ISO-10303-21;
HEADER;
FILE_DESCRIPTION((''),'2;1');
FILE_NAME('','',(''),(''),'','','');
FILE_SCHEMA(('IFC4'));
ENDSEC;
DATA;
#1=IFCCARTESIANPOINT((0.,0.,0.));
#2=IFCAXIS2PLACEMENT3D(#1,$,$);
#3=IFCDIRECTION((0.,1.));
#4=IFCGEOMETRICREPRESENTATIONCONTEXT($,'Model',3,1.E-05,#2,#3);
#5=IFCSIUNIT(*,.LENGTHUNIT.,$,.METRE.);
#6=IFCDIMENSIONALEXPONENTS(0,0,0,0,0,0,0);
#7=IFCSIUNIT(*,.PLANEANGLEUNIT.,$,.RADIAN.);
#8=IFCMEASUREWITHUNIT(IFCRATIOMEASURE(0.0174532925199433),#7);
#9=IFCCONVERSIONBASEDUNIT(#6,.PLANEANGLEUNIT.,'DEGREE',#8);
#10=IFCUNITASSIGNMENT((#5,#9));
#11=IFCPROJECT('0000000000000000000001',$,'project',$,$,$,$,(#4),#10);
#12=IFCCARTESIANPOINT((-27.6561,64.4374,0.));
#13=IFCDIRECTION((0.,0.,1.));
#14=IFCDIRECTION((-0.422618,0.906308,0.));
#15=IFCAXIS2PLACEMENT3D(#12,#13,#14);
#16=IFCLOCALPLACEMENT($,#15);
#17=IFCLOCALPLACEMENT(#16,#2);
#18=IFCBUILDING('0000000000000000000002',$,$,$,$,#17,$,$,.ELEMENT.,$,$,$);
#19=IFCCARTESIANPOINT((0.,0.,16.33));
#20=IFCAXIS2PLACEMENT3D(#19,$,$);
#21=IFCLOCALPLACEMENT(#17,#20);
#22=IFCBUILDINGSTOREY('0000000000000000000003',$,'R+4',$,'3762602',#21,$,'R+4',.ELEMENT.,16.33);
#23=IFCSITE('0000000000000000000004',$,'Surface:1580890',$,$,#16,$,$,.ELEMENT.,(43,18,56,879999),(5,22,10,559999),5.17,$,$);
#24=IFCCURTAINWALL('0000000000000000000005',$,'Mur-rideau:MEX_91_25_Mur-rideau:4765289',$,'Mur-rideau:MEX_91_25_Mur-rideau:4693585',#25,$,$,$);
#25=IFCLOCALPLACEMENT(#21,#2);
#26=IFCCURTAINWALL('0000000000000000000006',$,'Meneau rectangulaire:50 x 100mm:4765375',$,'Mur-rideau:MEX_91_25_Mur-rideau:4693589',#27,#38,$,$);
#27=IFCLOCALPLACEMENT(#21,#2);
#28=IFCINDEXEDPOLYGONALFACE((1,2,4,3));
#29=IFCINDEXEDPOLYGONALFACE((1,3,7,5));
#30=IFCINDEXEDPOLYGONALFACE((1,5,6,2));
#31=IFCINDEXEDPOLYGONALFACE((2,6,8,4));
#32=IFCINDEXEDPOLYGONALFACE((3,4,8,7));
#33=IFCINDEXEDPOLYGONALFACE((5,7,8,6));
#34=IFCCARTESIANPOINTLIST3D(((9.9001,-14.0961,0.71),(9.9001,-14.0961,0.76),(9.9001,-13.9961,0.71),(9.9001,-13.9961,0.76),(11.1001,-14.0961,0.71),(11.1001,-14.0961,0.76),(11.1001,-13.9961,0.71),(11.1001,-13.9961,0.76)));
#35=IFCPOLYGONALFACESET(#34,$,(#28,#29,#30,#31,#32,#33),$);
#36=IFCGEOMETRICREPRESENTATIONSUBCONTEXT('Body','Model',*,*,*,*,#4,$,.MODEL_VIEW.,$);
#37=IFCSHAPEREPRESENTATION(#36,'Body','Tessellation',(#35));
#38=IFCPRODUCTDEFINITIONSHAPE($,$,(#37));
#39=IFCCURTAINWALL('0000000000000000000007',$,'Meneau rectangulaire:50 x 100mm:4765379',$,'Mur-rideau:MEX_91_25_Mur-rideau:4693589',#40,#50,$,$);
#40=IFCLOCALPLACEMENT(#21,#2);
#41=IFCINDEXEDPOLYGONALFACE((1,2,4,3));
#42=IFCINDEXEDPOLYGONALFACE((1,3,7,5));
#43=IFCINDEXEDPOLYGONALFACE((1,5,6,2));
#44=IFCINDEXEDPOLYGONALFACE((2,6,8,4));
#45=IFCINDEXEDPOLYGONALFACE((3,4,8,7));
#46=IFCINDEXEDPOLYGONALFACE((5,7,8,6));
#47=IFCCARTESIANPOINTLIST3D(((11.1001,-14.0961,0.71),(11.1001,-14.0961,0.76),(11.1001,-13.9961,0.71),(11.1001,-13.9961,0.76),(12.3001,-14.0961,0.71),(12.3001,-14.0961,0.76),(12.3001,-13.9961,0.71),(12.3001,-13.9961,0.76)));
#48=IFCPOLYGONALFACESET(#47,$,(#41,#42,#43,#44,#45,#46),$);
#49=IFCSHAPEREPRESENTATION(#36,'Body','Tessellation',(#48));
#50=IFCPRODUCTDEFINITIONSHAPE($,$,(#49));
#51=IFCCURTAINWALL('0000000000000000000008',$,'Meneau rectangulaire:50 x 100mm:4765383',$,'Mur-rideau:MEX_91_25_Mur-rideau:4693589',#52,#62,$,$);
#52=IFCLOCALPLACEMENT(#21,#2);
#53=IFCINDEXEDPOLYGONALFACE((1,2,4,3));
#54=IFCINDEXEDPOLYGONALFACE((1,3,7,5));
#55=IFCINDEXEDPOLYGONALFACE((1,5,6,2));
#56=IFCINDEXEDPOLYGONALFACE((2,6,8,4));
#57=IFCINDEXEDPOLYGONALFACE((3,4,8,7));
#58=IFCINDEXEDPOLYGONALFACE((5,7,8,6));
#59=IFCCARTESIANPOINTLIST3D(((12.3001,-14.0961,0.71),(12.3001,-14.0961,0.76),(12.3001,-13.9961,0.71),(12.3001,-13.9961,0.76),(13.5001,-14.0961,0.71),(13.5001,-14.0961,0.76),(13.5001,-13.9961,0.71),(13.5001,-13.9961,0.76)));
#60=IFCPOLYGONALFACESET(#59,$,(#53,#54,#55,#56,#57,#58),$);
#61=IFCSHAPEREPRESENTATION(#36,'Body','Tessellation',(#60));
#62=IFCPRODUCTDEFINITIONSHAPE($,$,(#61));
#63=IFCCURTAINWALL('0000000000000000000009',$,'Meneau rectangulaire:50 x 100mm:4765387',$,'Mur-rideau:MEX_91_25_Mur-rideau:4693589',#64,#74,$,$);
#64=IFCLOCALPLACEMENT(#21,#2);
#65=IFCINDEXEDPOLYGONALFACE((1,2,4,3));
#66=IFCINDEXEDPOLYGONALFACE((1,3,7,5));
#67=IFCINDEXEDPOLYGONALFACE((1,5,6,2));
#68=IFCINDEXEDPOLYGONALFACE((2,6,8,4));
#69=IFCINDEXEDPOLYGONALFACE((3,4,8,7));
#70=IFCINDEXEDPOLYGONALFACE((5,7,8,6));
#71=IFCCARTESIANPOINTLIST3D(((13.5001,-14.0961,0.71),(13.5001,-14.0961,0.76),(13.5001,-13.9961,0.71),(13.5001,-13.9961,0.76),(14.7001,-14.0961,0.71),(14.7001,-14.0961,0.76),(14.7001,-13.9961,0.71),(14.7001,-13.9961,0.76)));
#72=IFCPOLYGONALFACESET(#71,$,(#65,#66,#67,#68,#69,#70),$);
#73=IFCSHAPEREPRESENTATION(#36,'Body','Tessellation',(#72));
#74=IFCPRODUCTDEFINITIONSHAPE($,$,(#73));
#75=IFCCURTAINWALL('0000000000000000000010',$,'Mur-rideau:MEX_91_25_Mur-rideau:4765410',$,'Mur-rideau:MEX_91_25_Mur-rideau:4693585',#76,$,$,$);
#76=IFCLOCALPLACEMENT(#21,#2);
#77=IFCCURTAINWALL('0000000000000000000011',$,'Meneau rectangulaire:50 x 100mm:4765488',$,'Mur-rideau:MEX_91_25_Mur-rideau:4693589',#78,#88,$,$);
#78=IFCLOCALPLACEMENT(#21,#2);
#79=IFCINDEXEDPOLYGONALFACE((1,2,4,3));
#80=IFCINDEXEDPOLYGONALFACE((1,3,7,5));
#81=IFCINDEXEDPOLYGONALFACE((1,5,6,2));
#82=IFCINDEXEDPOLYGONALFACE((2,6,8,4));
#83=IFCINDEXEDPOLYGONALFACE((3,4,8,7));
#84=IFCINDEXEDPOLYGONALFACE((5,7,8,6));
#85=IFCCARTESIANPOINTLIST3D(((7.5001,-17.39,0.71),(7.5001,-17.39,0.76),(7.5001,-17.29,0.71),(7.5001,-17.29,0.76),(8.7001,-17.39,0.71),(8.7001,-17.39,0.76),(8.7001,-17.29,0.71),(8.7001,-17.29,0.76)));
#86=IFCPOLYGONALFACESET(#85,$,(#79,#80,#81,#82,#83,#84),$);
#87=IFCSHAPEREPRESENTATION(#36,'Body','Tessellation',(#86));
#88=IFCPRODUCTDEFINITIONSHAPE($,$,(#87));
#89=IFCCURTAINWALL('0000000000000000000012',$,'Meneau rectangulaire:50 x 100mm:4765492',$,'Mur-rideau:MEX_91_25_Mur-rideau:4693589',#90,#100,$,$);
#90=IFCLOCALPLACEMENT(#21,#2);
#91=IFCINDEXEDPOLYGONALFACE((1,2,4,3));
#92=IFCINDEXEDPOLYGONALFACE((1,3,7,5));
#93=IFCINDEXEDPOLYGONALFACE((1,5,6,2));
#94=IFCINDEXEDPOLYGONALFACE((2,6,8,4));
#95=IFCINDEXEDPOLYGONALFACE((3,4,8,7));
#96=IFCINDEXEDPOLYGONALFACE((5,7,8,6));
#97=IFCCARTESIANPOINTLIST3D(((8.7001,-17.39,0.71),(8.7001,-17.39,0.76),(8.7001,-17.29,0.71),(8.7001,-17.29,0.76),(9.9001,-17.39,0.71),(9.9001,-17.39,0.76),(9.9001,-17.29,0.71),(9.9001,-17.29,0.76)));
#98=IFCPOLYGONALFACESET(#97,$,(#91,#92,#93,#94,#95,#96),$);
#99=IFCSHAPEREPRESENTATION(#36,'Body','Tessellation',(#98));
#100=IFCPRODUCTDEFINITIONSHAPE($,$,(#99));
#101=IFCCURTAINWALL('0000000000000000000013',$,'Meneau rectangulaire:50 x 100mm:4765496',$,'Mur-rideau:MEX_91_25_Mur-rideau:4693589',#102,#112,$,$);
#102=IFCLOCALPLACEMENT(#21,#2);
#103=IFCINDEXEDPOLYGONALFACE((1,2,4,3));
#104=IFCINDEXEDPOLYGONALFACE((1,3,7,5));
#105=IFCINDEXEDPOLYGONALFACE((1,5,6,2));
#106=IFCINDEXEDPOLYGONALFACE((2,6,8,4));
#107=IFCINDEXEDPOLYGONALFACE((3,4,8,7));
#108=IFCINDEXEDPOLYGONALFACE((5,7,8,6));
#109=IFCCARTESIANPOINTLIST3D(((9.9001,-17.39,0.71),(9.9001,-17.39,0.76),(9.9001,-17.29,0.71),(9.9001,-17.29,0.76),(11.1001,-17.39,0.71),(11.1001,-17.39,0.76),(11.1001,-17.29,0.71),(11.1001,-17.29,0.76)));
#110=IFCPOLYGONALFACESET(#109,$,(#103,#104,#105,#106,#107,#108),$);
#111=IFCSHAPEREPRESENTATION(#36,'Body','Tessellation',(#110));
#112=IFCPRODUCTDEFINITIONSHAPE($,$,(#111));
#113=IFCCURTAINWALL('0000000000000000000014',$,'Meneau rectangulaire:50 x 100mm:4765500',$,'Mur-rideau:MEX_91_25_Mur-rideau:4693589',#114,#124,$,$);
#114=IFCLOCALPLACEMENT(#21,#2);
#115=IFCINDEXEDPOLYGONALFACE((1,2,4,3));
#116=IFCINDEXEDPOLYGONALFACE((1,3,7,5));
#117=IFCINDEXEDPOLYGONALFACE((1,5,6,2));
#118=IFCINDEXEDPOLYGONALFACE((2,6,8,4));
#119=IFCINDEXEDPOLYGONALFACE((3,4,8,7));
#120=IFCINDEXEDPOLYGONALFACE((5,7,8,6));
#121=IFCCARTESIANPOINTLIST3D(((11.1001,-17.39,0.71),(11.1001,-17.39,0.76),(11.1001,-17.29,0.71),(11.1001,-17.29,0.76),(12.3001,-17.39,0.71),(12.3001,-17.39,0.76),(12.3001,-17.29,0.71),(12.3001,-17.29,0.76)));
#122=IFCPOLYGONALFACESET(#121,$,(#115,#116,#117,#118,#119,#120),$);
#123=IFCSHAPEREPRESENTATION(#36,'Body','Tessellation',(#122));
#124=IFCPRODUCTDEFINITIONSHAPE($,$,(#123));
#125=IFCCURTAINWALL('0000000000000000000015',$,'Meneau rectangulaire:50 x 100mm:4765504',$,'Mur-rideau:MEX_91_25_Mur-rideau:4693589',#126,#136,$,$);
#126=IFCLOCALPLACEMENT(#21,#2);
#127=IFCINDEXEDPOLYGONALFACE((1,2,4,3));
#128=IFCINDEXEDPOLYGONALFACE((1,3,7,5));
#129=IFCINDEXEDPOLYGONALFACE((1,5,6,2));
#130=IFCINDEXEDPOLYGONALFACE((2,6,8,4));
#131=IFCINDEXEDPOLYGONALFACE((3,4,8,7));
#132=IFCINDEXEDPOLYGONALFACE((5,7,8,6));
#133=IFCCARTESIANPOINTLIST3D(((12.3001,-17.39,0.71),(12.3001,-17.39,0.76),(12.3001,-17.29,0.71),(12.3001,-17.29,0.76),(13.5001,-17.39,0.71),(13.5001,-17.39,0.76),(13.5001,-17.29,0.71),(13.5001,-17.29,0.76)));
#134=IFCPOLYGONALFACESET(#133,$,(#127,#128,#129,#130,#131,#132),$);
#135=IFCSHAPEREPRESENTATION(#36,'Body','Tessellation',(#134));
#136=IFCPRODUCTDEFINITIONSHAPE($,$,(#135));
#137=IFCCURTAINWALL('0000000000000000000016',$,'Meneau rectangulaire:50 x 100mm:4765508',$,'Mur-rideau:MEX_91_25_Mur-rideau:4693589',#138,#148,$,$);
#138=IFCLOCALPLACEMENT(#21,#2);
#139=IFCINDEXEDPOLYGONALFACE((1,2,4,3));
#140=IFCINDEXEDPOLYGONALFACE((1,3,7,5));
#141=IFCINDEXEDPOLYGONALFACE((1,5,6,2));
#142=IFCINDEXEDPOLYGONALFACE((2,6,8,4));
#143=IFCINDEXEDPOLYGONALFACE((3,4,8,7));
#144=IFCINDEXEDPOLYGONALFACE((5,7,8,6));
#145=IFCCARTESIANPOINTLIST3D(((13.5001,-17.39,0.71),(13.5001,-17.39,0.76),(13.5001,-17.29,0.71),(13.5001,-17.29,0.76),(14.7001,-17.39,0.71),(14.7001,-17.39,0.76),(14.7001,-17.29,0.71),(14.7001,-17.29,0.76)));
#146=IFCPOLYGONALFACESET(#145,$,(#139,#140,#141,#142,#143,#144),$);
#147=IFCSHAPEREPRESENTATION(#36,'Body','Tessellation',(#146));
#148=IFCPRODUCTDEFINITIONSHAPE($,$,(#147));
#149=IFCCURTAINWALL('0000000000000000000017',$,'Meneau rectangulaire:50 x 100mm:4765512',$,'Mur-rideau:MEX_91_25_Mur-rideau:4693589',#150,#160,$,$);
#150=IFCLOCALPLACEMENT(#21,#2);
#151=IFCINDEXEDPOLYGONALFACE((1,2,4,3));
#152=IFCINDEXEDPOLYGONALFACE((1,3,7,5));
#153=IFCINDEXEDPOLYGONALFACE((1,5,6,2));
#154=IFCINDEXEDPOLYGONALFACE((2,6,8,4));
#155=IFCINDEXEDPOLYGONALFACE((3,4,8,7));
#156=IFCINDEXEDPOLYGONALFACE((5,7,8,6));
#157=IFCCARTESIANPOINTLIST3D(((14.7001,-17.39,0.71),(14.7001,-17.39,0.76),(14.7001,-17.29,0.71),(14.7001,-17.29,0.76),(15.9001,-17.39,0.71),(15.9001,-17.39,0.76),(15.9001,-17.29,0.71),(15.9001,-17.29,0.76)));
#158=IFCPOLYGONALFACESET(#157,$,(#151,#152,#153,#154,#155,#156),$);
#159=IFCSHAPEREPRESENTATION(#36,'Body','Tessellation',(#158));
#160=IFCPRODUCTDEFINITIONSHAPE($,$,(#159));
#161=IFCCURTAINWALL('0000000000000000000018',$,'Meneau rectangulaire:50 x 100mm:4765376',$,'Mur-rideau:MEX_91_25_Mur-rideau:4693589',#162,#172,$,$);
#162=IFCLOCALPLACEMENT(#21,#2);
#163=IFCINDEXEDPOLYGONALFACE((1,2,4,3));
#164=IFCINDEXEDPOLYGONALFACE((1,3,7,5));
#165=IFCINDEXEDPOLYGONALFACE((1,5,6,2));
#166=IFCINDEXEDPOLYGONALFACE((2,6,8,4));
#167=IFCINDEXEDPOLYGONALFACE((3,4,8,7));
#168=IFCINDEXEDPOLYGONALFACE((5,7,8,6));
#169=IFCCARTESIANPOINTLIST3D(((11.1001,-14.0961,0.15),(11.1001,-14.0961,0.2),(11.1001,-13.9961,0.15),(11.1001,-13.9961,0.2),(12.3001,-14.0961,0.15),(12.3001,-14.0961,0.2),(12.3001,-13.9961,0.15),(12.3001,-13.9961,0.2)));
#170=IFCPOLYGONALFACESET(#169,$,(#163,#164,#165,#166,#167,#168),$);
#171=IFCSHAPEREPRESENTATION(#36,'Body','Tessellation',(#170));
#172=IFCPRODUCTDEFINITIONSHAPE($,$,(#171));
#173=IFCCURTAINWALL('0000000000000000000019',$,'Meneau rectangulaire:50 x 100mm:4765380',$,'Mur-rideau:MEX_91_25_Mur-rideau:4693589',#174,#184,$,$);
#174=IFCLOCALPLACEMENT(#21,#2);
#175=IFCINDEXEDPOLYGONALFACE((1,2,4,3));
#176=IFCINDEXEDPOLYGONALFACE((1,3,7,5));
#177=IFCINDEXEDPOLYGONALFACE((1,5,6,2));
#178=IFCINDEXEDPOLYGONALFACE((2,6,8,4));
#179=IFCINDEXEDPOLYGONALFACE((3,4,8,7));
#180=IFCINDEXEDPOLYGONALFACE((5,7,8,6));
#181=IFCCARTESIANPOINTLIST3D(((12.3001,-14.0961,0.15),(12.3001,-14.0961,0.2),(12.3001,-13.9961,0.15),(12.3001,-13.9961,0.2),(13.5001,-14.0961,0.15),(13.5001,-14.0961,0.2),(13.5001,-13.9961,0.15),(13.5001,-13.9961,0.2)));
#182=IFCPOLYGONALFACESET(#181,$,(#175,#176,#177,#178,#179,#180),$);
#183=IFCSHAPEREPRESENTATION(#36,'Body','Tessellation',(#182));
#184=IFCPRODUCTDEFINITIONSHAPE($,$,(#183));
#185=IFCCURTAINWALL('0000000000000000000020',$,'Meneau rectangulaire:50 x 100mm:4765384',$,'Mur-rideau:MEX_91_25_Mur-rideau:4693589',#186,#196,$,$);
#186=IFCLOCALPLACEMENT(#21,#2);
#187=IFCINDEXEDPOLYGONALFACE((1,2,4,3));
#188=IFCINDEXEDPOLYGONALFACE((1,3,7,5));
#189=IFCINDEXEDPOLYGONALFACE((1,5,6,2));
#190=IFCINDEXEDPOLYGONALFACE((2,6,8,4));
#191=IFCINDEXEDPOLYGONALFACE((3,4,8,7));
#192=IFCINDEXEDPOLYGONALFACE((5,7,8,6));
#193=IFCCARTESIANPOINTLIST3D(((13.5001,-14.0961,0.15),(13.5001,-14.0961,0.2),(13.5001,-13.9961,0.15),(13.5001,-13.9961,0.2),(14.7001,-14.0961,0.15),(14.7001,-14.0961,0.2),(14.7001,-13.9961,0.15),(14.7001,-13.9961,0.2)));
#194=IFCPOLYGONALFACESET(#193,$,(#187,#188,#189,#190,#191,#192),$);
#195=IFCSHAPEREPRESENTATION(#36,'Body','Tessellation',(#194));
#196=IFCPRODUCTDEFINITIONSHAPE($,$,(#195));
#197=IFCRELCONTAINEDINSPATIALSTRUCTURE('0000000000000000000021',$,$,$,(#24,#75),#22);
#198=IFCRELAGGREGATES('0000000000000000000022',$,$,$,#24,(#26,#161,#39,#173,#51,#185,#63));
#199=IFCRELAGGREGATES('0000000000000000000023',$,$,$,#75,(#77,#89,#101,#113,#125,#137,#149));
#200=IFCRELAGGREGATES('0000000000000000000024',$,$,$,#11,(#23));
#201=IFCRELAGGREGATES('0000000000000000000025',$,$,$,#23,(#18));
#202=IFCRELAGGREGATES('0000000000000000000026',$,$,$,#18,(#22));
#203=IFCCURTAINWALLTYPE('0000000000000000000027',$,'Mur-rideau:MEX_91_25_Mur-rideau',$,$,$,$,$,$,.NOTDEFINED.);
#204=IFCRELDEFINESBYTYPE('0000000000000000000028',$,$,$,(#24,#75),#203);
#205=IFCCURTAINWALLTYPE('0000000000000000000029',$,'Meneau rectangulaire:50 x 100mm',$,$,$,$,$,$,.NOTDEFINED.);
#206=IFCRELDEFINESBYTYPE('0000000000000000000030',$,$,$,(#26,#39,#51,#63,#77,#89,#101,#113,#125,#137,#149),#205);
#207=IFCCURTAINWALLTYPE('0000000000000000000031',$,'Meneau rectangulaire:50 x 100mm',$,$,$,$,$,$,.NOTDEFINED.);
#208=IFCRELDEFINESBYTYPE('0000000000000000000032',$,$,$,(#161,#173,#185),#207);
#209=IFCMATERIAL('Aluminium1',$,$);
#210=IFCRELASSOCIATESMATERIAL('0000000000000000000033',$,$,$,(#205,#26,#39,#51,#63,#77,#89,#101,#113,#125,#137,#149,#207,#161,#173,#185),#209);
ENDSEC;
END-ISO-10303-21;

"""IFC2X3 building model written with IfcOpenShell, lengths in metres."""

from ifc_helpers import new_model, entity, si_unit, converted_unit, direction, frame, origin, origin_2d_with_axis, place, context, subcontext, project, spatial, rectangle, extrude, source, transform, mapped, material, type_object, type_shapes, element, aggregate, save


model = new_model("IFC2X3")

# Units and contexts
model_context = context("Model", 3, precision=1e-05, world=origin(), true_north=direction((0.0, 1.0)))
body_context = subcontext(model_context, "Body", "Model", "MODEL_VIEW")
ifc_project = project(units=[si_unit("LENGTHUNIT", "METRE"), converted_unit("PLANEANGLEUNIT", "DEGREE", entity("IfcRatioMeasure", 0.0174532925199433), si_unit("PLANEANGLEUNIT", "RADIAN"), dimensions=[0, 0, 0, 0, 0, 0, 0])], contexts=[model_context])

# Site, building, storey
site_placement = place(None, frame((-27.6561, 64.4374, 0.0), z_axis=(0.0, 0.0, 1.0), x_axis=(-0.422618, 0.906308, 0.0)))
site = spatial("IfcSite", under=ifc_project, at=site_placement, Name="Surface:1580890", CompositionType="ELEMENT", RefLatitude=(43, 18, 56, 879999), RefLongitude=(5, 22, 10, 559999), RefElevation=5.17)
building_placement = place(site_placement, origin())
building = spatial("IfcBuilding", under=site, at=building_placement, CompositionType="ELEMENT")
storey_placement = place(building_placement, frame((0.0, 0.0, 16.33)))
storey = spatial("IfcBuildingStorey", under=building, at=storey_placement, Name="R+4", ObjectType="3762602", LongName="R+4", CompositionType="ELEMENT", Elevation=16.33)

# Curtain walls
curtain_wall_type_1 = type_object("IfcCurtainWallType", Name="Mur-rideau:MEX_91_25_Mur-rideau", PredefinedType="NOTDEFINED")
curtain_wall_1_placement = place(storey_placement, frame((0.0, 0.0, -16.33)))
curtain_wall_1 = element("IfcCurtainWall", 1, at=curtain_wall_1_placement, inside=storey, type_object=curtain_wall_type_1, Name="Mur-rideau:MEX_91_25_Mur-rideau:4765289", ObjectType="Mur-rideau:MEX_91_25_Mur-rideau:4693585")
ifc_material = material(Name="Aluminium1")
curtain_wall_type_2 = type_object("IfcCurtainWallType", Name="Meneau rectangulaire:50 x 100mm", PredefinedType="NOTDEFINED", material=ifc_material)
shared_shape_1 = source(origin(), body_context, "Body", "SweptSolid", [
    extrude(rectangle(XDim=0.05, YDim=0.1, at=origin_2d_with_axis()), frame((-0.025, 0.0, -1.2), z_axis=(0.0, 0.0, 1.0), x_axis=(-1.0, 0.0, 0.0)), (0.0, 0.0, 1.0), 1.2),
])
type_shapes(curtain_wall_type_2, [shared_shape_1])
placement = place(building_placement, frame((0.0, 0.0, -2.88)))
curtain_wall_2_placement = place(placement, frame((11.1001, -14.0461, 19.97), z_axis=(1.0, 0.0, 0.0), x_axis=(0.0, 0.0, 1.0)))
curtain_wall_2 = element("IfcCurtainWall", 2, at=curtain_wall_2_placement, type_object=curtain_wall_type_2, material=ifc_material, Name="Meneau rectangulaire:50 x 100mm:4765375", ObjectType="Mur-rideau:MEX_91_25_Mur-rideau:4693589", context=body_context, shape_type="MappedRepresentation", body=[
    mapped(shared_shape_1, transform((0.0, 0.0, 0.0), scale=1.0)),
])
curtain_wall_3_placement = place(placement, frame((12.3001, -14.0461, 19.97), z_axis=(1.0, 0.0, 0.0), x_axis=(0.0, 0.0, 1.0)))
curtain_wall_3 = element("IfcCurtainWall", 3, at=curtain_wall_3_placement, type_object=curtain_wall_type_2, material=ifc_material, Name="Meneau rectangulaire:50 x 100mm:4765379", ObjectType="Mur-rideau:MEX_91_25_Mur-rideau:4693589", context=body_context, shape_type="MappedRepresentation", body=[
    mapped(shared_shape_1, transform((0.0, 0.0, 0.0), scale=1.0)),
])
curtain_wall_4_placement = place(placement, frame((13.5001, -14.0461, 19.97), z_axis=(1.0, 0.0, 0.0), x_axis=(0.0, 0.0, 1.0)))
curtain_wall_4 = element("IfcCurtainWall", 4, at=curtain_wall_4_placement, type_object=curtain_wall_type_2, material=ifc_material, Name="Meneau rectangulaire:50 x 100mm:4765383", ObjectType="Mur-rideau:MEX_91_25_Mur-rideau:4693589", context=body_context, shape_type="MappedRepresentation", body=[
    mapped(shared_shape_1, transform((0.0, 0.0, 0.0), scale=1.0)),
])
curtain_wall_5_placement = place(placement, frame((14.7001, -14.0461, 19.97), z_axis=(1.0, 0.0, 0.0), x_axis=(0.0, 0.0, 1.0)))
curtain_wall_5 = element("IfcCurtainWall", 5, at=curtain_wall_5_placement, type_object=curtain_wall_type_2, material=ifc_material, Name="Meneau rectangulaire:50 x 100mm:4765387", ObjectType="Mur-rideau:MEX_91_25_Mur-rideau:4693589", context=body_context, shape_type="MappedRepresentation", body=[
    mapped(shared_shape_1, transform((0.0, 0.0, 0.0), scale=1.0)),
])
curtain_wall_6_placement = place(storey_placement, frame((0.0, 0.0, -16.33)))
curtain_wall_6 = element("IfcCurtainWall", 6, at=curtain_wall_6_placement, inside=storey, type_object=curtain_wall_type_1, Name="Mur-rideau:MEX_91_25_Mur-rideau:4765410", ObjectType="Mur-rideau:MEX_91_25_Mur-rideau:4693585")
curtain_wall_7_placement = place(placement, frame((8.7001, -17.34, 19.97), z_axis=(1.0, 0.0, 0.0), x_axis=(0.0, 0.0, 1.0)))
curtain_wall_7 = element("IfcCurtainWall", 7, at=curtain_wall_7_placement, type_object=curtain_wall_type_2, material=ifc_material, Name="Meneau rectangulaire:50 x 100mm:4765488", ObjectType="Mur-rideau:MEX_91_25_Mur-rideau:4693589", context=body_context, shape_type="MappedRepresentation", body=[
    mapped(shared_shape_1, transform((0.0, 0.0, 0.0), scale=1.0)),
])
curtain_wall_8_placement = place(placement, frame((9.9001, -17.34, 19.97), z_axis=(1.0, 0.0, 0.0), x_axis=(0.0, 0.0, 1.0)))
curtain_wall_8 = element("IfcCurtainWall", 8, at=curtain_wall_8_placement, type_object=curtain_wall_type_2, material=ifc_material, Name="Meneau rectangulaire:50 x 100mm:4765492", ObjectType="Mur-rideau:MEX_91_25_Mur-rideau:4693589", context=body_context, shape_type="MappedRepresentation", body=[
    mapped(shared_shape_1, transform((0.0, 0.0, 0.0), scale=1.0)),
])
curtain_wall_9_placement = place(placement, frame((11.1001, -17.34, 19.97), z_axis=(1.0, 0.0, 0.0), x_axis=(0.0, 0.0, 1.0)))
curtain_wall_9 = element("IfcCurtainWall", 9, at=curtain_wall_9_placement, type_object=curtain_wall_type_2, material=ifc_material, Name="Meneau rectangulaire:50 x 100mm:4765496", ObjectType="Mur-rideau:MEX_91_25_Mur-rideau:4693589", context=body_context, shape_type="MappedRepresentation", body=[
    mapped(shared_shape_1, transform((0.0, 0.0, 0.0), scale=1.0)),
])
curtain_wall_10_placement = place(placement, frame((12.3001, -17.34, 19.97), z_axis=(1.0, 0.0, 0.0), x_axis=(0.0, 0.0, 1.0)))
curtain_wall_10 = element("IfcCurtainWall", 10, at=curtain_wall_10_placement, type_object=curtain_wall_type_2, material=ifc_material, Name="Meneau rectangulaire:50 x 100mm:4765500", ObjectType="Mur-rideau:MEX_91_25_Mur-rideau:4693589", context=body_context, shape_type="MappedRepresentation", body=[
    mapped(shared_shape_1, transform((0.0, 0.0, 0.0), scale=1.0)),
])
curtain_wall_11_placement = place(placement, frame((13.5001, -17.34, 19.97), z_axis=(1.0, 0.0, 0.0), x_axis=(0.0, 0.0, 1.0)))
curtain_wall_11 = element("IfcCurtainWall", 11, at=curtain_wall_11_placement, type_object=curtain_wall_type_2, material=ifc_material, Name="Meneau rectangulaire:50 x 100mm:4765504", ObjectType="Mur-rideau:MEX_91_25_Mur-rideau:4693589", context=body_context, shape_type="MappedRepresentation", body=[
    mapped(shared_shape_1, transform((0.0, 0.0, 0.0), scale=1.0)),
])
curtain_wall_12_placement = place(placement, frame((14.7001, -17.34, 19.97), z_axis=(1.0, 0.0, 0.0), x_axis=(0.0, 0.0, 1.0)))
curtain_wall_12 = element("IfcCurtainWall", 12, at=curtain_wall_12_placement, type_object=curtain_wall_type_2, material=ifc_material, Name="Meneau rectangulaire:50 x 100mm:4765508", ObjectType="Mur-rideau:MEX_91_25_Mur-rideau:4693589", context=body_context, shape_type="MappedRepresentation", body=[
    mapped(shared_shape_1, transform((0.0, 0.0, 0.0), scale=1.0)),
])
curtain_wall_13_placement = place(placement, frame((15.9001, -17.34, 19.97), z_axis=(1.0, 0.0, 0.0), x_axis=(0.0, 0.0, 1.0)))
curtain_wall_13 = element("IfcCurtainWall", 13, at=curtain_wall_13_placement, type_object=curtain_wall_type_2, material=ifc_material, Name="Meneau rectangulaire:50 x 100mm:4765512", ObjectType="Mur-rideau:MEX_91_25_Mur-rideau:4693589", context=body_context, shape_type="MappedRepresentation", body=[
    mapped(shared_shape_1, transform((0.0, 0.0, 0.0), scale=1.0)),
])

# Curtain walls
curtain_wall_type_3 = type_object("IfcCurtainWallType", Name="Meneau rectangulaire:50 x 100mm", PredefinedType="NOTDEFINED", material=ifc_material)
shared_shape_2 = source(origin(), body_context, "Body", "SweptSolid", [
    extrude(rectangle(XDim=0.05, YDim=0.1, at=origin_2d_with_axis()), frame((-0.025, 0.0, -1.2), z_axis=(0.0, 0.0, 1.0), x_axis=(-1.0, 0.0, 0.0)), (0.0, 0.0, 1.0), 1.2),
])
type_shapes(curtain_wall_type_3, [shared_shape_2])
curtain_wall_14_placement = place(placement, frame((11.1001, -14.0461, 19.36), z_axis=(-1.0, 0.0, 0.0), x_axis=(0.0, 0.0, -1.0)))
curtain_wall_14 = element("IfcCurtainWall", 14, at=curtain_wall_14_placement, type_object=curtain_wall_type_3, material=ifc_material, Name="Meneau rectangulaire:50 x 100mm:4765376", ObjectType="Mur-rideau:MEX_91_25_Mur-rideau:4693589", context=body_context, shape_type="MappedRepresentation", body=[
    mapped(shared_shape_2, transform((0.0, 0.0, 0.0), scale=1.0)),
])
curtain_wall_15_placement = place(placement, frame((12.3001, -14.0461, 19.36), z_axis=(-1.0, 0.0, 0.0), x_axis=(0.0, 0.0, -1.0)))
curtain_wall_15 = element("IfcCurtainWall", 15, at=curtain_wall_15_placement, type_object=curtain_wall_type_3, material=ifc_material, Name="Meneau rectangulaire:50 x 100mm:4765380", ObjectType="Mur-rideau:MEX_91_25_Mur-rideau:4693589", context=body_context, shape_type="MappedRepresentation", body=[
    mapped(shared_shape_2, transform((0.0, 0.0, 0.0), scale=1.0)),
])
curtain_wall_16_placement = place(placement, frame((13.5001, -14.0461, 19.36), z_axis=(-1.0, 0.0, 0.0), x_axis=(0.0, 0.0, -1.0)))
curtain_wall_16 = element("IfcCurtainWall", 16, at=curtain_wall_16_placement, type_object=curtain_wall_type_3, material=ifc_material, Name="Meneau rectangulaire:50 x 100mm:4765384", ObjectType="Mur-rideau:MEX_91_25_Mur-rideau:4693589", context=body_context, shape_type="MappedRepresentation", body=[
    mapped(shared_shape_2, transform((0.0, 0.0, 0.0), scale=1.0)),
])
aggregate(curtain_wall_1, [curtain_wall_2, curtain_wall_14, curtain_wall_3, curtain_wall_15, curtain_wall_4, curtain_wall_16, curtain_wall_5])
aggregate(curtain_wall_6, [curtain_wall_7, curtain_wall_8, curtain_wall_9, curtain_wall_10, curtain_wall_11, curtain_wall_12, curtain_wall_13])

save(model, "model.ifc")
